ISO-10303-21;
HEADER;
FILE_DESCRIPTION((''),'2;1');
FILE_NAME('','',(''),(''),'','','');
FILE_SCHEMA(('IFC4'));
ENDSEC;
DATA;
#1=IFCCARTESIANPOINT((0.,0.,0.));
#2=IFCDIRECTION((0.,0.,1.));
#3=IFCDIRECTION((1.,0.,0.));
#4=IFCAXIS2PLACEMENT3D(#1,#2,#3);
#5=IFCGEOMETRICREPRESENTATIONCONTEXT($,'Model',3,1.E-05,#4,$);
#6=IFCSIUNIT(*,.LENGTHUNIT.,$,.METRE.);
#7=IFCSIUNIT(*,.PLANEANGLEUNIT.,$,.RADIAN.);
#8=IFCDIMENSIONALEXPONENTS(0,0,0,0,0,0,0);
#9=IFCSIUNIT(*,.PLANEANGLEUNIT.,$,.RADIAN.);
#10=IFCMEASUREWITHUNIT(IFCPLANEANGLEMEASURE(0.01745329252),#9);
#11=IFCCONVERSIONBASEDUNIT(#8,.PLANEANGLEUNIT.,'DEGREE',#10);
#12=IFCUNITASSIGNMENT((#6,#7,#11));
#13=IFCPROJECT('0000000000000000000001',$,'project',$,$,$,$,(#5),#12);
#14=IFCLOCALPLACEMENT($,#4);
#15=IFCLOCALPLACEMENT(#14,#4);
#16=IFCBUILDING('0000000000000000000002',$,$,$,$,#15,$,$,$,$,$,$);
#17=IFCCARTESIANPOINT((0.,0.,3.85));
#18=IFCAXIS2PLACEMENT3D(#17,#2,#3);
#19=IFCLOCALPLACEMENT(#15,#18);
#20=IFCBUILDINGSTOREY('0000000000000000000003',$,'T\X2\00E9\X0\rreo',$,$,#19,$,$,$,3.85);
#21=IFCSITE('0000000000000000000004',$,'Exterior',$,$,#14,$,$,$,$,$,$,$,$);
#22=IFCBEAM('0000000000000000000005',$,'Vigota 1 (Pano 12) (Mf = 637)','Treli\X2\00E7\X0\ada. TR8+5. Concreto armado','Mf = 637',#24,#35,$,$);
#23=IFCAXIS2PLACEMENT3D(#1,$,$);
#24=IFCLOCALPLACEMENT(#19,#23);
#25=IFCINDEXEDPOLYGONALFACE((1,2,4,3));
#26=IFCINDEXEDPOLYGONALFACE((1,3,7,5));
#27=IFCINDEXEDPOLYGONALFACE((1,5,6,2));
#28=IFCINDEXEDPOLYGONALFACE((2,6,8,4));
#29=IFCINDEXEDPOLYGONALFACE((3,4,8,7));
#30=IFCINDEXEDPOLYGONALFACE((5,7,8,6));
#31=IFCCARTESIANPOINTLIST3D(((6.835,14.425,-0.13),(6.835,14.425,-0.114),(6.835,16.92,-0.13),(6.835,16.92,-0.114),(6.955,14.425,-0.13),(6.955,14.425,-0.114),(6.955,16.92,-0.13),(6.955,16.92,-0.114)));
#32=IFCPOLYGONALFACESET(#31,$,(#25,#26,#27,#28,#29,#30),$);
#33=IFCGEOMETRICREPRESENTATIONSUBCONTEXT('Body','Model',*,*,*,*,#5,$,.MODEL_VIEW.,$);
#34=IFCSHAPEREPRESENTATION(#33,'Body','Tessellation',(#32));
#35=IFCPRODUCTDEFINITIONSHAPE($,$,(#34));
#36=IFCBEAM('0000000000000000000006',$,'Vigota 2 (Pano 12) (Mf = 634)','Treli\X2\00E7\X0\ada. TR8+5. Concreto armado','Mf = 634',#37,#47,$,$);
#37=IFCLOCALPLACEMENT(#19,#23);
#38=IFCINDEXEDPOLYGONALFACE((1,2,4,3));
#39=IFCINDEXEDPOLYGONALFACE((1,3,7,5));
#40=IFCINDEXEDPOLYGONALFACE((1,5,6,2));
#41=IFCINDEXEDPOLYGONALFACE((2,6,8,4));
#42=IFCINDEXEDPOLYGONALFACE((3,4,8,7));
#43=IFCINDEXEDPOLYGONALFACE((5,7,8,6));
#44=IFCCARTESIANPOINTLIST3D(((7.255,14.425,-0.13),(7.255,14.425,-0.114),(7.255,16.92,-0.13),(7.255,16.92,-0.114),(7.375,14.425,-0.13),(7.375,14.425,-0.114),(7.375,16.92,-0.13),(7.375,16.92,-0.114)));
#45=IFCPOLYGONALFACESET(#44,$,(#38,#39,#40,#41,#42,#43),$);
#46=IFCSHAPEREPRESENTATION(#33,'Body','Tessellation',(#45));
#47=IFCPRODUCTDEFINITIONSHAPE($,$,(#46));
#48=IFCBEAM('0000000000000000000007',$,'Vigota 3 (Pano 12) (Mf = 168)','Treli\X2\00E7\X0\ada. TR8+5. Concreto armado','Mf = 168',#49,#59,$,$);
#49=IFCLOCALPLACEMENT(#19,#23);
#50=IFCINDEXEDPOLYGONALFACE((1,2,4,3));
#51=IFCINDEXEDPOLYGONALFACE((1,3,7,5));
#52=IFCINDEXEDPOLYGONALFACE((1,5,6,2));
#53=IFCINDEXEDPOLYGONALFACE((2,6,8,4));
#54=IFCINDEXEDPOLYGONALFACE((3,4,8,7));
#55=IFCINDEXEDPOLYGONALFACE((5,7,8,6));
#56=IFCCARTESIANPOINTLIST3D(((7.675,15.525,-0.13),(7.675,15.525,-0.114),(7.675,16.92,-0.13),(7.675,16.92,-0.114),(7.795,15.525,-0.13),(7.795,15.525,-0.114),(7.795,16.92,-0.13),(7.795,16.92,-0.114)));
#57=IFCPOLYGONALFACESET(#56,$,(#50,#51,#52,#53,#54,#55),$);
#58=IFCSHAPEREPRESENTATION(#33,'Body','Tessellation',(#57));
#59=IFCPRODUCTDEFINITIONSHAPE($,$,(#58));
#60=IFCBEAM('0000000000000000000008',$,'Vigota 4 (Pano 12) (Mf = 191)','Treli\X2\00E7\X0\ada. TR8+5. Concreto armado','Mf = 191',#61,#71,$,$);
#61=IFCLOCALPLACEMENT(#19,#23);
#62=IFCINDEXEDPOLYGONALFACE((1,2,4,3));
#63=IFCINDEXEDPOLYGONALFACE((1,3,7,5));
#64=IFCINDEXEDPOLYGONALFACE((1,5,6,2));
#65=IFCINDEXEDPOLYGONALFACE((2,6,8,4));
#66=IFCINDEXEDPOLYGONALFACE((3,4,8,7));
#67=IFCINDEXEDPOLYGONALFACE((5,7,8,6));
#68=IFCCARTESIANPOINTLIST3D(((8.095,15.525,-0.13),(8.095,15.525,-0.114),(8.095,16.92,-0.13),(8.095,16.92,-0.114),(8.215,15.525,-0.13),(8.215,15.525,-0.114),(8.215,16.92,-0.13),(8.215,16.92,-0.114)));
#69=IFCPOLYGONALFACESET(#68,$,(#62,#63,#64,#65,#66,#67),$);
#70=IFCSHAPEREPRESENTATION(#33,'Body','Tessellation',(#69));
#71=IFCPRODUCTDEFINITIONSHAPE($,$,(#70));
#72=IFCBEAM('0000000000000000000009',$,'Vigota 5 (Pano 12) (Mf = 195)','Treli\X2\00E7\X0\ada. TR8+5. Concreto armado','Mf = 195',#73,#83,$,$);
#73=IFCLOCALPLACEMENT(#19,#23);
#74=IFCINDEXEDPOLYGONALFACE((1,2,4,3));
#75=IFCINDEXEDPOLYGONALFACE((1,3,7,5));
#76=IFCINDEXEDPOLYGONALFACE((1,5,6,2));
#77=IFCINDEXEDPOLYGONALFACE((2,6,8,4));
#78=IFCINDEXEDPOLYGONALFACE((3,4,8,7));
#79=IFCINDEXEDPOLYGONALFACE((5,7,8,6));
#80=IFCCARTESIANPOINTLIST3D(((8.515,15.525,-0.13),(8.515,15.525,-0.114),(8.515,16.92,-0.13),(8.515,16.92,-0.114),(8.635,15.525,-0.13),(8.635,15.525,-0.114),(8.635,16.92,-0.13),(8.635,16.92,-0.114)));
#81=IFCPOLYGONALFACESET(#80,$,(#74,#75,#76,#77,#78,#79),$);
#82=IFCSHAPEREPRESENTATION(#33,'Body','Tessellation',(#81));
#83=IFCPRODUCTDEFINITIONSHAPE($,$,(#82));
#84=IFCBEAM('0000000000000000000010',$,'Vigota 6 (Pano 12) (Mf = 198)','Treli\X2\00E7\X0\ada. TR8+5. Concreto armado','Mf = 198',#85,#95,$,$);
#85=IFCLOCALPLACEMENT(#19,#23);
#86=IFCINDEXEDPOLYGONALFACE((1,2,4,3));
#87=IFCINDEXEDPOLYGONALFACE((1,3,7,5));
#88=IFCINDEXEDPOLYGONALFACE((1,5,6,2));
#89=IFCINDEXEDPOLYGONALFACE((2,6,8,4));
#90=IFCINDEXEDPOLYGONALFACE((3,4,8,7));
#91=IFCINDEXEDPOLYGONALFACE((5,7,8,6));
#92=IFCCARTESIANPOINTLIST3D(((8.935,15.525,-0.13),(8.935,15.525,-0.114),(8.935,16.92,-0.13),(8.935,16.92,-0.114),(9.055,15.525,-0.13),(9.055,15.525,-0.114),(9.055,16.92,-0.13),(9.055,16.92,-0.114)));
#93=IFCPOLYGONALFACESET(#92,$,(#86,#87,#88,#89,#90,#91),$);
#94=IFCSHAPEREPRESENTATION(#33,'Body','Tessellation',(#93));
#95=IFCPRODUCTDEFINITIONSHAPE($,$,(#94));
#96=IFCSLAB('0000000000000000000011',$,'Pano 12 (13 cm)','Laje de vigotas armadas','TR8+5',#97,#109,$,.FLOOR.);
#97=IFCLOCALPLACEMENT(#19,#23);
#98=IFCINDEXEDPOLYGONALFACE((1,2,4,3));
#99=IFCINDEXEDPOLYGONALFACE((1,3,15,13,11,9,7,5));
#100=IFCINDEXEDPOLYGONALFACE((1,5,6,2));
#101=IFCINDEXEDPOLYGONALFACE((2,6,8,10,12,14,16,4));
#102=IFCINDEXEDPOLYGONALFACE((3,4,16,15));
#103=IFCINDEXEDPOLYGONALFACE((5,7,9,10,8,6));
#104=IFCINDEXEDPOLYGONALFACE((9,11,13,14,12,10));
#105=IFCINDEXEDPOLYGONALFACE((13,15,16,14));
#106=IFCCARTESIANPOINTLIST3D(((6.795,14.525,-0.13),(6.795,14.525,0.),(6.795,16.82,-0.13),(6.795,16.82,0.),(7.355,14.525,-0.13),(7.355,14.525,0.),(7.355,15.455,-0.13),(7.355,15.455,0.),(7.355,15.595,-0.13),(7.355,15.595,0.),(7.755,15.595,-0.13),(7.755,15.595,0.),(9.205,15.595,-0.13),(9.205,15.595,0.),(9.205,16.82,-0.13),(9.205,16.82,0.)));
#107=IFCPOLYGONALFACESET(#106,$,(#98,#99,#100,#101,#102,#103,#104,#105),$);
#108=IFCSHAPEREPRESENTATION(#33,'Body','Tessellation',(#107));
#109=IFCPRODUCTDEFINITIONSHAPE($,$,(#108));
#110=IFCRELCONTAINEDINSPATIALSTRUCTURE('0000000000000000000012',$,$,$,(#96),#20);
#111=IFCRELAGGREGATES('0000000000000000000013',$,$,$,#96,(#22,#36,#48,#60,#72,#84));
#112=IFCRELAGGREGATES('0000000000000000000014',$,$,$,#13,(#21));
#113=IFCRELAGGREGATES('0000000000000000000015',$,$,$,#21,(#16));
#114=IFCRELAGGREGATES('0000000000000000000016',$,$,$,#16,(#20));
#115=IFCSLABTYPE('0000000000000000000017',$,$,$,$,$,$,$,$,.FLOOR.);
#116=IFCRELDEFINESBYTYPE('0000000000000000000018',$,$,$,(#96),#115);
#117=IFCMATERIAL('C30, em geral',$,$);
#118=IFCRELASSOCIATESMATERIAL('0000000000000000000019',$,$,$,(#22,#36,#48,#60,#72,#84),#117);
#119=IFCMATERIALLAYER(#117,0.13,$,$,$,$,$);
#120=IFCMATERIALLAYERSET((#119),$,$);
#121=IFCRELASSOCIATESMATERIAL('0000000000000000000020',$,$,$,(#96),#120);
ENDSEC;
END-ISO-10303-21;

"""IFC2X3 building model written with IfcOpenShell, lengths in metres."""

from ifc_helpers import new_model, entity, si_unit, converted_unit, frame, origin_with_axes, place, context, subcontext, project, spatial, polyline, outline, extrude, material, layer, layer_set, layer_usage, type_object, element, aggregate, save


model = new_model("IFC2X3")

# Units and contexts
model_context = context("Model", 3, precision=1e-05, world=origin_with_axes())
body_context = subcontext(model_context, "Body", "Model", "MODEL_VIEW")
ifc_project = project(units=[si_unit("LENGTHUNIT", "METRE"), si_unit("PLANEANGLEUNIT", "RADIAN"), converted_unit("PLANEANGLEUNIT", "DEGREE", entity("IfcPlaneAngleMeasure", 0.01745329252), si_unit("PLANEANGLEUNIT", "RADIAN"), dimensions=[0, 0, 0, 0, 0, 0, 0])], contexts=[model_context])

# Site, building, storey
site_placement = place(None, origin_with_axes())
site = spatial("IfcSite", under=ifc_project, at=site_placement, Name="Exterior")
building_placement = place(site_placement, origin_with_axes())
building = spatial("IfcBuilding", under=site, at=building_placement)
storey_placement = place(building_placement, frame((0.0, 0.0, 3.85), z_axis=(0.0, 0.0, 1.0), x_axis=(1.0, 0.0, 0.0)))
storey = spatial("IfcBuildingStorey", under=building, at=storey_placement, Name="Térreo", Elevation=3.85)

# Beams
ifc_material_1 = material(Name="C30, em geral")
beam_1_placement = place(storey_placement, frame((6.895, 14.425, -0.122), z_axis=(0.0, 1.0, 0.0), x_axis=(-1.0, 0.0, 0.0)))
beam_1 = element("IfcBeam", 1, at=beam_1_placement, material=ifc_material_1, Name="Vigota 1 (Pano 12) (Mf = 637)", Description="Treliçada. TR8+5. Concreto armado", ObjectType="Mf = 637", context=body_context, shape_type="SweptSolid", body=[
    extrude(outline(polyline([(0.06, 0.008), (-0.06, 0.008), (-0.06, -0.008), (0.06, -0.008), (0.06, 0.008)])), origin_with_axes(), (0.0, 0.0, 1.0), 2.495),
])
beam_2_placement = place(storey_placement, frame((7.315, 14.425, -0.122), z_axis=(0.0, 1.0, 0.0), x_axis=(-1.0, 0.0, 0.0)))
beam_2 = element("IfcBeam", 2, at=beam_2_placement, material=ifc_material_1, Name="Vigota 2 (Pano 12) (Mf = 634)", Description="Treliçada. TR8+5. Concreto armado", ObjectType="Mf = 634", context=body_context, shape_type="SweptSolid", body=[
    extrude(outline(polyline([(0.06, 0.008), (-0.06, 0.008), (-0.06, -0.008), (0.06, -0.008), (0.06, 0.008)])), origin_with_axes(), (0.0, 0.0, 1.0), 2.495),
])
beam_3_placement = place(storey_placement, frame((7.735, 15.525, -0.122), z_axis=(0.0, 1.0, 0.0), x_axis=(-1.0, 0.0, 0.0)))
beam_3 = element("IfcBeam", 3, at=beam_3_placement, material=ifc_material_1, Name="Vigota 3 (Pano 12) (Mf = 168)", Description="Treliçada. TR8+5. Concreto armado", ObjectType="Mf = 168", context=body_context, shape_type="SweptSolid", body=[
    extrude(outline(polyline([(0.06, 0.008), (-0.06, 0.008), (-0.06, -0.008), (0.06, -0.008), (0.06, 0.008)])), origin_with_axes(), (0.0, 0.0, 1.0), 1.395),
])
beam_4_placement = place(storey_placement, frame((8.155, 15.525, -0.122), z_axis=(0.0, 1.0, 0.0), x_axis=(-1.0, 0.0, 0.0)))
beam_4 = element("IfcBeam", 4, at=beam_4_placement, material=ifc_material_1, Name="Vigota 4 (Pano 12) (Mf = 191)", Description="Treliçada. TR8+5. Concreto armado", ObjectType="Mf = 191", context=body_context, shape_type="SweptSolid", body=[
    extrude(outline(polyline([(0.06, 0.008), (-0.06, 0.008), (-0.06, -0.008), (0.06, -0.008), (0.06, 0.008)])), origin_with_axes(), (0.0, 0.0, 1.0), 1.395),
])
beam_5_placement = place(storey_placement, frame((8.575, 15.525, -0.122), z_axis=(0.0, 1.0, 0.0), x_axis=(-1.0, 0.0, 0.0)))
beam_5 = element("IfcBeam", 5, at=beam_5_placement, material=ifc_material_1, Name="Vigota 5 (Pano 12) (Mf = 195)", Description="Treliçada. TR8+5. Concreto armado", ObjectType="Mf = 195", context=body_context, shape_type="SweptSolid", body=[
    extrude(outline(polyline([(0.06, 0.008), (-0.06, 0.008), (-0.06, -0.008), (0.06, -0.008), (0.06, 0.008)])), origin_with_axes(), (0.0, 0.0, 1.0), 1.395),
])
beam_6_placement = place(storey_placement, frame((8.995, 15.525, -0.122), z_axis=(0.0, 1.0, 0.0), x_axis=(-1.0, 0.0, 0.0)))
beam_6 = element("IfcBeam", 6, at=beam_6_placement, material=ifc_material_1, Name="Vigota 6 (Pano 12) (Mf = 198)", Description="Treliçada. TR8+5. Concreto armado", ObjectType="Mf = 198", context=body_context, shape_type="SweptSolid", body=[
    extrude(outline(polyline([(0.06, 0.008), (-0.06, 0.008), (-0.06, -0.008), (0.06, -0.008), (0.06, 0.008)])), origin_with_axes(), (0.0, 0.0, 1.0), 1.395),
])

# Slab
slab_type = type_object("IfcSlabType", PredefinedType="FLOOR")
ifc_layer_1 = layer(ifc_material_1, 0.13)
ifc_layer_set_1 = layer_set([ifc_layer_1])
ifc_layer_usage_1 = layer_usage(ifc_layer_set_1, "AXIS3", "POSITIVE", 0.0)
slab_1_placement = place(storey_placement, frame((0.0, 0.0, -0.13), z_axis=(0.0, 0.0, 1.0), x_axis=(1.0, 0.0, 0.0)))
slab_1 = element("IfcSlab", 7, at=slab_1_placement, inside=storey, type_object=slab_type, material=ifc_layer_usage_1, Name="Pano 12 (13 cm)", Description="Laje de vigotas armadas", ObjectType="TR8+5", PredefinedType="FLOOR", context=body_context, shape_type="SweptSolid", body=[
    extrude(outline(polyline([(7.355, 15.455), (7.355, 15.595), (7.755, 15.595), (9.205, 15.595), (9.205, 16.82), (6.795, 16.82), (6.795, 14.525), (7.355, 14.525), (7.355, 15.455)])), origin_with_axes(), (0.0, 0.0, 1.0), 0.13),
])
aggregate(slab_1, [beam_1, beam_2, beam_3, beam_4, beam_5, beam_6])

save(model, "model.ifc")
